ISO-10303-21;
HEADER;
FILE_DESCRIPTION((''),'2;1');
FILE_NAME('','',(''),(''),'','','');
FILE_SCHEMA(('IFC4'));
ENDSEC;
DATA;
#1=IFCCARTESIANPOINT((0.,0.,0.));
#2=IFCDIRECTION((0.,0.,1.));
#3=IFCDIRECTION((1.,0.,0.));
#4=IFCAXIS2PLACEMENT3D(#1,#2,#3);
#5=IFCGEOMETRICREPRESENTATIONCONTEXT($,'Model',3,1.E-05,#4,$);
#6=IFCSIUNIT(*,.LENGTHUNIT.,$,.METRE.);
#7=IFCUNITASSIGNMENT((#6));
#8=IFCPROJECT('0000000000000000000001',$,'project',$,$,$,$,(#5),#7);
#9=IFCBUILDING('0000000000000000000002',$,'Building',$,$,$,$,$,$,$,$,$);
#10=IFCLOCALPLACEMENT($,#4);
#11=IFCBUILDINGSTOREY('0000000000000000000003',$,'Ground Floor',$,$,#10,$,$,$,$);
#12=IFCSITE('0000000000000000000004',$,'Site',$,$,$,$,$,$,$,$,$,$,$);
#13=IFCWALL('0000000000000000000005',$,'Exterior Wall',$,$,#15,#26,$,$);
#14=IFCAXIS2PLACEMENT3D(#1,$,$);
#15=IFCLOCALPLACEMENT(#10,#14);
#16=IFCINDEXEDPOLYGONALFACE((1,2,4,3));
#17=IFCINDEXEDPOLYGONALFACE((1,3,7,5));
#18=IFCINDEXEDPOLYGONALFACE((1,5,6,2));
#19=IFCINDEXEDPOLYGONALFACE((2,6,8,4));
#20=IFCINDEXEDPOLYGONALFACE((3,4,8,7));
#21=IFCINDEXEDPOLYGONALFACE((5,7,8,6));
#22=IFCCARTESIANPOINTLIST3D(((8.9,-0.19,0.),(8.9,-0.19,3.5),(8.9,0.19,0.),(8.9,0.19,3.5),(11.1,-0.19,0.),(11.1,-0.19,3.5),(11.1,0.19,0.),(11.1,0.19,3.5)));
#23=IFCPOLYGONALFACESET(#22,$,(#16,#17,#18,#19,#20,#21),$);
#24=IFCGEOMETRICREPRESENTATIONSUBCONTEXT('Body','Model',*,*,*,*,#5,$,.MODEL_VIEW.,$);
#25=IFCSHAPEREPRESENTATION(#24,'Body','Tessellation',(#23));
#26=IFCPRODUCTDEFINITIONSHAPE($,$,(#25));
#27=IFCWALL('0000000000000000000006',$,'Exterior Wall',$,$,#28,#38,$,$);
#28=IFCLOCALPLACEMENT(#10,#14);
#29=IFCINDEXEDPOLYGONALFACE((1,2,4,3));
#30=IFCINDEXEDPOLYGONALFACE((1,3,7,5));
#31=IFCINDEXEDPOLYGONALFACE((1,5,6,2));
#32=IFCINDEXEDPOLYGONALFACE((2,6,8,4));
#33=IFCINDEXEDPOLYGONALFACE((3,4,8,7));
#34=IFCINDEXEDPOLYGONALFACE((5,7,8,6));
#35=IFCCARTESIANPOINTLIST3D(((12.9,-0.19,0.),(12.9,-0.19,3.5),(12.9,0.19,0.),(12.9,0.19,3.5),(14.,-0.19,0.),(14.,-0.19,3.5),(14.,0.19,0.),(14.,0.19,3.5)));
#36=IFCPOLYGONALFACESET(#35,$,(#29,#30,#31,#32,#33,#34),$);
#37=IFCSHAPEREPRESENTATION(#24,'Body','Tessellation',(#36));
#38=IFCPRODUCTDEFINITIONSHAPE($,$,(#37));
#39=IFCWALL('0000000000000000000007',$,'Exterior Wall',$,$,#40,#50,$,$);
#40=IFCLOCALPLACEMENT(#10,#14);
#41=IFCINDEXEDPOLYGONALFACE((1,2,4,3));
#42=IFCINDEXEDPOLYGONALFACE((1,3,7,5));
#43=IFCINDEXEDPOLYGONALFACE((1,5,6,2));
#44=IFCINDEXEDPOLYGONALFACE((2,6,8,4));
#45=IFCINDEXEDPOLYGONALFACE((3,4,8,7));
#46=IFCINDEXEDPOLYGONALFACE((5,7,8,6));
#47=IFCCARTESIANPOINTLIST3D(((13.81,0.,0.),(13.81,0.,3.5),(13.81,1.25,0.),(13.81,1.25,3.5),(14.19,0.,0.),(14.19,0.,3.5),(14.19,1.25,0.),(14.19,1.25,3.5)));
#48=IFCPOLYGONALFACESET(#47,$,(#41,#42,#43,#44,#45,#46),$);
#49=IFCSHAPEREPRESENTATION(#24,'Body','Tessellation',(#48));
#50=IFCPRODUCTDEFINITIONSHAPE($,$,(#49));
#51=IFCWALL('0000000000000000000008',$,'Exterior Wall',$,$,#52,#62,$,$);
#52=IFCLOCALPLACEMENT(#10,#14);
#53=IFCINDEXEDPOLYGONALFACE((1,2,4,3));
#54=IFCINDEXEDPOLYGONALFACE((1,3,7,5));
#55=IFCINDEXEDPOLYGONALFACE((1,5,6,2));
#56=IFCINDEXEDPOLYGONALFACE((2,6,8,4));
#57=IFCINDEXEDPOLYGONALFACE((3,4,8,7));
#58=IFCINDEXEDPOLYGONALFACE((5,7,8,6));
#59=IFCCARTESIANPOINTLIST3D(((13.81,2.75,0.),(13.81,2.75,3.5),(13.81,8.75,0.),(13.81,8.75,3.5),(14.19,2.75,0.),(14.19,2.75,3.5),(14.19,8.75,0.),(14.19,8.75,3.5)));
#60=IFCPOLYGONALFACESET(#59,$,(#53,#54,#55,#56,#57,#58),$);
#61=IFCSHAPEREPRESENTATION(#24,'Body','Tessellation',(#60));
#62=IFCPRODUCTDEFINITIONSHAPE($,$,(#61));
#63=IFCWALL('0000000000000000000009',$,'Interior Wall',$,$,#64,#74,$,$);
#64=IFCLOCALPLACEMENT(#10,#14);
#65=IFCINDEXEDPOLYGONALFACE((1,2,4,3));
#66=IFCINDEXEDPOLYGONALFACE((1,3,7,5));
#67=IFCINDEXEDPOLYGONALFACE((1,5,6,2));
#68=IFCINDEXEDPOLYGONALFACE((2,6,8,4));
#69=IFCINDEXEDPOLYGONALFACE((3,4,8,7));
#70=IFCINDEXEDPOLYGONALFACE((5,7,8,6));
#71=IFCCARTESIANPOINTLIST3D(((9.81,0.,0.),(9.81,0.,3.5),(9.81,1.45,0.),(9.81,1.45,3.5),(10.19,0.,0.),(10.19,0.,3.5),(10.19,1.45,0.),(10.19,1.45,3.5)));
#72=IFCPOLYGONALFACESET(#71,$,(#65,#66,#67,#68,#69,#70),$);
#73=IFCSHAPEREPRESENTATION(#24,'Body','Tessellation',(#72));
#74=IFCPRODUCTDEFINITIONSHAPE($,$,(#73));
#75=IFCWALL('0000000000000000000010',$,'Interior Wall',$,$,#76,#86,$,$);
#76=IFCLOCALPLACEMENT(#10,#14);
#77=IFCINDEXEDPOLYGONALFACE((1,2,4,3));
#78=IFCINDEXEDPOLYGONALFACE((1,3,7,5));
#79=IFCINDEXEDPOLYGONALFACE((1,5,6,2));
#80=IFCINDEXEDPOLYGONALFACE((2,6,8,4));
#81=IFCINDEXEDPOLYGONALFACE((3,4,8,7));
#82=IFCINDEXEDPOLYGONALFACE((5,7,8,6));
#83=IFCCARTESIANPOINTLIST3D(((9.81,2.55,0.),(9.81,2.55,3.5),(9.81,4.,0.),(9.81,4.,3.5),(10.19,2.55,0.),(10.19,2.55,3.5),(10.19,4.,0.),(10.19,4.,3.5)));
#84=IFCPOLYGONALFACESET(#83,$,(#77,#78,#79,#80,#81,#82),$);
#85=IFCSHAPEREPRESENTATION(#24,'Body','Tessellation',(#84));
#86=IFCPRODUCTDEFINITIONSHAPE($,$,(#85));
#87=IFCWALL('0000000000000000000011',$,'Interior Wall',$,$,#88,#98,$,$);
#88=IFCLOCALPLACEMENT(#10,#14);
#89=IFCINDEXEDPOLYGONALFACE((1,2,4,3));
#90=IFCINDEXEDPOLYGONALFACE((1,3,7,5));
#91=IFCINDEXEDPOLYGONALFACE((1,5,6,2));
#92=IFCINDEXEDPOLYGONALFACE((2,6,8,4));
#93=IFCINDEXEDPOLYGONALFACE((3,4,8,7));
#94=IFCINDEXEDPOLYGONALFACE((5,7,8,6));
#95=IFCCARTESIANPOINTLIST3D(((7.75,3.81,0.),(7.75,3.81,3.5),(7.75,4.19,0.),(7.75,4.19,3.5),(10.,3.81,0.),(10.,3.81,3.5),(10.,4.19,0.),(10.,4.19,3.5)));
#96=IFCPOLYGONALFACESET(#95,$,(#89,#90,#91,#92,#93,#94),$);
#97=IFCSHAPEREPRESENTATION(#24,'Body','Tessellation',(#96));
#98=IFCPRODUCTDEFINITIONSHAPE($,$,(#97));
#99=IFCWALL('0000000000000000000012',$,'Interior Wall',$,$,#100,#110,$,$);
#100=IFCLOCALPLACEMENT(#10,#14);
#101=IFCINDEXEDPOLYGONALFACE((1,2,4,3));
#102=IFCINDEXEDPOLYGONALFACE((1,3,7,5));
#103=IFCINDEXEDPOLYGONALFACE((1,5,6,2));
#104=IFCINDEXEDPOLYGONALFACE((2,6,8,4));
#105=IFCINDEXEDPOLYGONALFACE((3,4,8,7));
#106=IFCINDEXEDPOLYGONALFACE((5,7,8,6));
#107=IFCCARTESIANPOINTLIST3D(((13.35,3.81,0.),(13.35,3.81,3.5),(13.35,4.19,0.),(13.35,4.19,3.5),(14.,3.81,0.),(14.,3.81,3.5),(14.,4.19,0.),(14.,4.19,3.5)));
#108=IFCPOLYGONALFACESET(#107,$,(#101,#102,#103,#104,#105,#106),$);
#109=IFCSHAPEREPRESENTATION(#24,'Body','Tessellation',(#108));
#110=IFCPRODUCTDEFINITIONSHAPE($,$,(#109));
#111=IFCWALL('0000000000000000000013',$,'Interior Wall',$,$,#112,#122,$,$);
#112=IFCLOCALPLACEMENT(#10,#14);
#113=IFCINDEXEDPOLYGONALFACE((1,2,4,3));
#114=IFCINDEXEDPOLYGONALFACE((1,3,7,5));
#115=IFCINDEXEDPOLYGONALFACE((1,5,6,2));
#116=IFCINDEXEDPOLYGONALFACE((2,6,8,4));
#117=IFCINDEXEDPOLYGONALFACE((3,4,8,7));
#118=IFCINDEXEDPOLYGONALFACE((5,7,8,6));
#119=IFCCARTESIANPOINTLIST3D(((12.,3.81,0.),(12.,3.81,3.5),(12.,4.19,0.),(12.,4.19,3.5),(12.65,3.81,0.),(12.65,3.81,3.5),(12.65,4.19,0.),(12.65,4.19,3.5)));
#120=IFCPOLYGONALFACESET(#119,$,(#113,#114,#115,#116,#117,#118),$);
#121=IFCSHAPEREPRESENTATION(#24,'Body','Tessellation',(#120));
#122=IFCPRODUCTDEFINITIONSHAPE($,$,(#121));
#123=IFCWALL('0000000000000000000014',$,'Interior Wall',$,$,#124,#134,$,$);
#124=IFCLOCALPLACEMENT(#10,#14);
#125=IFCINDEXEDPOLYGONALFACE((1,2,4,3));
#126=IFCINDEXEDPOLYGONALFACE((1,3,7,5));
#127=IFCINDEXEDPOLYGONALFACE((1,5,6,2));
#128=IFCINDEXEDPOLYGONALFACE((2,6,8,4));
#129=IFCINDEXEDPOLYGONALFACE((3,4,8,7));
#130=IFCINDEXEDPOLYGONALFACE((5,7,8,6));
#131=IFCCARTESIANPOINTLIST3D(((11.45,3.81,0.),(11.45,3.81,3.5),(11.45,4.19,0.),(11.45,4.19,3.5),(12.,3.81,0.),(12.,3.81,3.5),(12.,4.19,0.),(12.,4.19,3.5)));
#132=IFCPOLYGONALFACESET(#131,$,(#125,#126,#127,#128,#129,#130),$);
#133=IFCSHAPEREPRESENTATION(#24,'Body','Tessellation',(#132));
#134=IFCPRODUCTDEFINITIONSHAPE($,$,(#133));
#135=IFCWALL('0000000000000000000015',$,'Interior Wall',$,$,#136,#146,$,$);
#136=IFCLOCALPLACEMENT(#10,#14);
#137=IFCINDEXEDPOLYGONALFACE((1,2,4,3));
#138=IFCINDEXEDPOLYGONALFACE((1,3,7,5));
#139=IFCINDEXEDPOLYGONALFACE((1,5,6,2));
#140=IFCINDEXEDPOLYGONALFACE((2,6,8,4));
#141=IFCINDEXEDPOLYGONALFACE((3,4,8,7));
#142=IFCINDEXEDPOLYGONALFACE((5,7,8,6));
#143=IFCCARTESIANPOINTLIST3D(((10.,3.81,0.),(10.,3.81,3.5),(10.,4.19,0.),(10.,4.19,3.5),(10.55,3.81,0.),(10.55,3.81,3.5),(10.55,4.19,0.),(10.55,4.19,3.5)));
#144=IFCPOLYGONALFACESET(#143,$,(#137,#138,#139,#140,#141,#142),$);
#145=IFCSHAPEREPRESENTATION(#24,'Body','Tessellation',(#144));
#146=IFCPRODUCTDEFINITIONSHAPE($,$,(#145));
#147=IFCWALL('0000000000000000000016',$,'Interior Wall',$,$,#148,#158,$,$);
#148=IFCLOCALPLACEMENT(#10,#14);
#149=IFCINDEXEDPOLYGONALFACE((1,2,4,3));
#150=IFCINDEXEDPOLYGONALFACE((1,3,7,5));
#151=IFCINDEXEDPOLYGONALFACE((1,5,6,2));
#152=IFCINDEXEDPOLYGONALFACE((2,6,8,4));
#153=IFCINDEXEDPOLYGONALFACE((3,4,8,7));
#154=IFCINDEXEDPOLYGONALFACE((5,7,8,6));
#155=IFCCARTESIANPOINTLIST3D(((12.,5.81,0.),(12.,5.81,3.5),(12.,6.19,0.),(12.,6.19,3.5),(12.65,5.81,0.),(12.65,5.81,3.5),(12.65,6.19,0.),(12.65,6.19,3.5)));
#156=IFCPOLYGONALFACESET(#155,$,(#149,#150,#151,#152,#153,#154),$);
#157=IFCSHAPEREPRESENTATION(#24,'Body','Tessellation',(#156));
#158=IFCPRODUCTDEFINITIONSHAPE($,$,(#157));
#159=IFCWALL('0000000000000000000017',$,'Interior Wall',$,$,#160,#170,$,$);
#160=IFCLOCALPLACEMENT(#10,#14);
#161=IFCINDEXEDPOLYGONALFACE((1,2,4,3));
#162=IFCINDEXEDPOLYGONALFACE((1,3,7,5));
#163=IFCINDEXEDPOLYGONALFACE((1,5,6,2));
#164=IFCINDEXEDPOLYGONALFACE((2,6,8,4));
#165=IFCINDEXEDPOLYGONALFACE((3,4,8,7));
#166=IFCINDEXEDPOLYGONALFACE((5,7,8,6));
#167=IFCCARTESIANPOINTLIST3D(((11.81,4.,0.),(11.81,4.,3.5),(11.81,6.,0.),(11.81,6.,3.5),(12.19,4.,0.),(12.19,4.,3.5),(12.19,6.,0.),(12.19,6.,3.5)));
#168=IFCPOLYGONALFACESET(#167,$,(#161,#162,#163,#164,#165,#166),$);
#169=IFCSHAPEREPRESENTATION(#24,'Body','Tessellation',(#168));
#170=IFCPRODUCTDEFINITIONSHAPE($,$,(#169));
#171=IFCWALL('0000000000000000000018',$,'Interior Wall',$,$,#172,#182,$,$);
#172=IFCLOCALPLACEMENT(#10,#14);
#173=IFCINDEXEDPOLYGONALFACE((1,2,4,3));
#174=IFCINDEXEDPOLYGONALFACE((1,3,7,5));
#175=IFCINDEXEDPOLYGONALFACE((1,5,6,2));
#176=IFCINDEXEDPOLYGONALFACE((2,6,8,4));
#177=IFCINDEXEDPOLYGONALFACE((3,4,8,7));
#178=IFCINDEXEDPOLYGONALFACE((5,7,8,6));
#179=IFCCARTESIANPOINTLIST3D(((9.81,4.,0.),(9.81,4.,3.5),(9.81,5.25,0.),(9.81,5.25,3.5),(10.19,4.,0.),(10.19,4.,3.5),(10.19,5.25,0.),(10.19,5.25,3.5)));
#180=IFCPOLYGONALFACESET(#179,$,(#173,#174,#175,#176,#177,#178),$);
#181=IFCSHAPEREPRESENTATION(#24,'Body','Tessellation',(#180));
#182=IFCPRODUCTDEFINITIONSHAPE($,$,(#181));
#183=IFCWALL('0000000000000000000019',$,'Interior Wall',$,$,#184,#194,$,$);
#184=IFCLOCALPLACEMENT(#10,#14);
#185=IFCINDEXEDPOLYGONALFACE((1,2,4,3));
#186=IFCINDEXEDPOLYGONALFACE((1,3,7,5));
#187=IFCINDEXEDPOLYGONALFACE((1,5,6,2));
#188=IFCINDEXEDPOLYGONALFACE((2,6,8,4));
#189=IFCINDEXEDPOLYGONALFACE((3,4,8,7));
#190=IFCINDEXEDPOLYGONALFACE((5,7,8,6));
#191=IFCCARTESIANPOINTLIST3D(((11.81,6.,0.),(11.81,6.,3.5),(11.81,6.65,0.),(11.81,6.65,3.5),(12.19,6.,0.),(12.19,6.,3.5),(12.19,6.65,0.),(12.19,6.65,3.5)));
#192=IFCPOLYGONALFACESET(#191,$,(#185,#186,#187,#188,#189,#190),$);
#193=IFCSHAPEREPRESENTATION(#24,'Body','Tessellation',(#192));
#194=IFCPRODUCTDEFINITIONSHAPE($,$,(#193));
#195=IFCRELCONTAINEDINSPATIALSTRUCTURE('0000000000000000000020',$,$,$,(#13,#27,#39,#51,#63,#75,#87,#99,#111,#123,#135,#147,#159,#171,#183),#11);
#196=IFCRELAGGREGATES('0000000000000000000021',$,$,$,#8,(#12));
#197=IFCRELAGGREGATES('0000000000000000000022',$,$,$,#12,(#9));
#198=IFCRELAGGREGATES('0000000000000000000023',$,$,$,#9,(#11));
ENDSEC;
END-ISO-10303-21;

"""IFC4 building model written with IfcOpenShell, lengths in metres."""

from ifc_helpers import new_model, si_unit, frame, origin_with_axes, place, context, subcontext, project, spatial, indexed_curve, outline, extrude, element, save


model = new_model("IFC4")

# Units and contexts
model_context = context("Model", 3, precision=1e-05, world=origin_with_axes())
body_context = subcontext(model_context, "Body", "Model", "MODEL_VIEW")
ifc_project = project(units=[si_unit("LENGTHUNIT", "METRE")], contexts=[model_context])

# Site, building, storey
site = spatial("IfcSite", under=ifc_project, Name="Site")
building = spatial("IfcBuilding", under=site, Name="Building")
storey_placement = place(None, origin_with_axes())
storey = spatial("IfcBuildingStorey", under=building, at=storey_placement, Name="Ground Floor")

# Walls
wall_1_placement = place(storey_placement, frame((8.9, 0.0, 0.0), z_axis=(0.0, 0.0, 1.0), x_axis=(1.0, 0.0, 0.0)))
element("IfcWall", 1, at=wall_1_placement, inside=storey, Name="Exterior Wall", context=body_context, shape_type="SweptSolid", body=[
    extrude(outline(indexed_curve([(0.0, 0.0), (0.0, 0.38), (2.2, 0.38), (2.2, 0.0), (0.0, 0.0)], self_intersect=False)), frame((0.0, -0.19, 0.0), z_axis=(0.0, 0.0, 1.0), x_axis=(1.0, 0.0, 0.0)), (0.0, 0.0, 1.0), 3.5),
])
wall_2_placement = place(storey_placement, frame((12.9, 0.0, 0.0), z_axis=(0.0, 0.0, 1.0), x_axis=(1.0, 0.0, 0.0)))
element("IfcWall", 2, at=wall_2_placement, inside=storey, Name="Exterior Wall", context=body_context, shape_type="SweptSolid", body=[
    extrude(outline(indexed_curve([(0.0, 0.0), (0.0, 0.38), (1.1, 0.38), (1.1, 0.0), (0.0, 0.0)], self_intersect=False)), frame((0.0, -0.19, 0.0), z_axis=(0.0, 0.0, 1.0), x_axis=(1.0, 0.0, 0.0)), (0.0, 0.0, 1.0), 3.5),
])
wall_3_placement = place(storey_placement, frame((14.0, 0.0, 0.0), z_axis=(0.0, 0.0, 1.0), x_axis=(0.0, 1.0, 0.0)))
element("IfcWall", 3, at=wall_3_placement, inside=storey, Name="Exterior Wall", context=body_context, shape_type="SweptSolid", body=[
    extrude(outline(indexed_curve([(0.0, 0.0), (0.0, 0.38), (1.25, 0.38), (1.25, 0.0), (0.0, 0.0)], self_intersect=False)), frame((0.0, -0.19, 0.0), z_axis=(0.0, 0.0, 1.0), x_axis=(1.0, 0.0, 0.0)), (0.0, 0.0, 1.0), 3.5),
])
wall_4_placement = place(storey_placement, frame((14.0, 2.75, 0.0), z_axis=(0.0, 0.0, 1.0), x_axis=(0.0, 1.0, 0.0)))
element("IfcWall", 4, at=wall_4_placement, inside=storey, Name="Exterior Wall", context=body_context, shape_type="SweptSolid", body=[
    extrude(outline(indexed_curve([(0.0, 0.0), (0.0, 0.38), (6.0, 0.38), (6.0, 0.0), (0.0, 0.0)], self_intersect=False)), frame((0.0, -0.19, 0.0), z_axis=(0.0, 0.0, 1.0), x_axis=(1.0, 0.0, 0.0)), (0.0, 0.0, 1.0), 3.5),
])
wall_5_placement = place(storey_placement, frame((10.0, 0.0, 0.0), z_axis=(0.0, 0.0, 1.0), x_axis=(0.0, 1.0, 0.0)))
element("IfcWall", 5, at=wall_5_placement, inside=storey, Name="Interior Wall", context=body_context, shape_type="SweptSolid", body=[
    extrude(outline(indexed_curve([(0.0, 0.0), (0.0, 0.38), (1.45, 0.38), (1.45, 0.0), (0.0, 0.0)], self_intersect=False)), frame((0.0, -0.19, 0.0), z_axis=(0.0, 0.0, 1.0), x_axis=(1.0, 0.0, 0.0)), (0.0, 0.0, 1.0), 3.5),
])
wall_6_placement = place(storey_placement, frame((10.0, 2.55, 0.0), z_axis=(0.0, 0.0, 1.0), x_axis=(0.0, 1.0, 0.0)))
element("IfcWall", 6, at=wall_6_placement, inside=storey, Name="Interior Wall", context=body_context, shape_type="SweptSolid", body=[
    extrude(outline(indexed_curve([(0.0, 0.0), (0.0, 0.38), (1.45, 0.38), (1.45, 0.0), (0.0, 0.0)], self_intersect=False)), frame((0.0, -0.19, 0.0), z_axis=(0.0, 0.0, 1.0), x_axis=(1.0, 0.0, 0.0)), (0.0, 0.0, 1.0), 3.5),
])
wall_7_placement = place(storey_placement, frame((10.0, 4.0, 0.0), z_axis=(0.0, 0.0, 1.0), x_axis=(-1.0, 0.0, 0.0)))
element("IfcWall", 7, at=wall_7_placement, inside=storey, Name="Interior Wall", context=body_context, shape_type="SweptSolid", body=[
    extrude(outline(indexed_curve([(0.0, 0.0), (0.0, 0.38), (2.25, 0.38), (2.25, 0.0), (0.0, 0.0)], self_intersect=False)), frame((0.0, -0.19, 0.0), z_axis=(0.0, 0.0, 1.0), x_axis=(1.0, 0.0, 0.0)), (0.0, 0.0, 1.0), 3.5),
])
for number, where, z_axis, x_axis, name in (
    (8, (14.0, 4.0, 0.0), (0.0, 0.0, 1.0), (-1.0, 0.0, 0.0), "Interior Wall"),
    (9, (12.65, 4.0, 0.0), (0.0, 0.0, 1.0), (-1.0, 0.0, 0.0), "Interior Wall"),
):
    element("IfcWall", number, at=place(storey_placement, frame(where, z_axis=z_axis, x_axis=x_axis)), inside=storey, Name=name, context=body_context, shape_type="SweptSolid", body=[
        extrude(outline(indexed_curve([(0.0, 0.0), (0.0, 0.38), (0.65, 0.38), (0.65, 0.0), (0.0, 0.0)], self_intersect=False)), frame((0.0, -0.19, 0.0), z_axis=(0.0, 0.0, 1.0), x_axis=(1.0, 0.0, 0.0)), (0.0, 0.0, 1.0), 3.5),
    ])
for number, where, z_axis, x_axis, name in (
    (10, (12.0, 4.0, 0.0), (0.0, 0.0, 1.0), (-1.0, 0.0, 0.0), "Interior Wall"),
    (11, (10.55, 4.0, 0.0), (0.0, 0.0, 1.0), (-1.0, 0.0, 0.0), "Interior Wall"),
):
    element("IfcWall", number, at=place(storey_placement, frame(where, z_axis=z_axis, x_axis=x_axis)), inside=storey, Name=name, context=body_context, shape_type="SweptSolid", body=[
        extrude(outline(indexed_curve([(0.0, 0.0), (0.0, 0.38), (0.55, 0.38), (0.55, 0.0), (0.0, 0.0)], self_intersect=False)), frame((0.0, -0.19, 0.0), z_axis=(0.0, 0.0, 1.0), x_axis=(1.0, 0.0, 0.0)), (0.0, 0.0, 1.0), 3.5),
    ])
wall_8_placement = place(storey_placement, frame((12.65, 6.0, 0.0), z_axis=(0.0, 0.0, 1.0), x_axis=(-1.0, 0.0, 0.0)))
element("IfcWall", 12, at=wall_8_placement, inside=storey, Name="Interior Wall", context=body_context, shape_type="SweptSolid", body=[
    extrude(outline(indexed_curve([(0.0, 0.0), (0.0, 0.38), (0.65, 0.38), (0.65, 0.0), (0.0, 0.0)], self_intersect=False)), frame((0.0, -0.19, 0.0), z_axis=(0.0, 0.0, 1.0), x_axis=(1.0, 0.0, 0.0)), (0.0, 0.0, 1.0), 3.5),
])
wall_9_placement = place(storey_placement, frame((12.0, 6.0, 0.0), z_axis=(0.0, 0.0, 1.0), x_axis=(0.0, -1.0, 0.0)))
element("IfcWall", 13, at=wall_9_placement, inside=storey, Name="Interior Wall", context=body_context, shape_type="SweptSolid", body=[
    extrude(outline(indexed_curve([(0.0, 0.0), (0.0, 0.38), (2.0, 0.38), (2.0, 0.0), (0.0, 0.0)], self_intersect=False)), frame((0.0, -0.19, 0.0), z_axis=(0.0, 0.0, 1.0), x_axis=(1.0, 0.0, 0.0)), (0.0, 0.0, 1.0), 3.5),
])
wall_10_placement = place(storey_placement, frame((10.0, 4.0, 0.0), z_axis=(0.0, 0.0, 1.0), x_axis=(0.0, 1.0, 0.0)))
element("IfcWall", 14, at=wall_10_placement, inside=storey, Name="Interior Wall", context=body_context, shape_type="SweptSolid", body=[
    extrude(outline(indexed_curve([(0.0, 0.0), (0.0, 0.38), (1.25, 0.38), (1.25, 0.0), (0.0, 0.0)], self_intersect=False)), frame((0.0, -0.19, 0.0), z_axis=(0.0, 0.0, 1.0), x_axis=(1.0, 0.0, 0.0)), (0.0, 0.0, 1.0), 3.5),
])
wall_11_placement = place(storey_placement, frame((12.0, 6.0, 0.0), z_axis=(0.0, 0.0, 1.0), x_axis=(0.0, 1.0, 0.0)))
element("IfcWall", 15, at=wall_11_placement, inside=storey, Name="Interior Wall", context=body_context, shape_type="SweptSolid", body=[
    extrude(outline(indexed_curve([(0.0, 0.0), (0.0, 0.38), (0.65, 0.38), (0.65, 0.0), (0.0, 0.0)], self_intersect=False)), frame((0.0, -0.19, 0.0), z_axis=(0.0, 0.0, 1.0), x_axis=(1.0, 0.0, 0.0)), (0.0, 0.0, 1.0), 3.5),
])

save(model, "model.ifc")
